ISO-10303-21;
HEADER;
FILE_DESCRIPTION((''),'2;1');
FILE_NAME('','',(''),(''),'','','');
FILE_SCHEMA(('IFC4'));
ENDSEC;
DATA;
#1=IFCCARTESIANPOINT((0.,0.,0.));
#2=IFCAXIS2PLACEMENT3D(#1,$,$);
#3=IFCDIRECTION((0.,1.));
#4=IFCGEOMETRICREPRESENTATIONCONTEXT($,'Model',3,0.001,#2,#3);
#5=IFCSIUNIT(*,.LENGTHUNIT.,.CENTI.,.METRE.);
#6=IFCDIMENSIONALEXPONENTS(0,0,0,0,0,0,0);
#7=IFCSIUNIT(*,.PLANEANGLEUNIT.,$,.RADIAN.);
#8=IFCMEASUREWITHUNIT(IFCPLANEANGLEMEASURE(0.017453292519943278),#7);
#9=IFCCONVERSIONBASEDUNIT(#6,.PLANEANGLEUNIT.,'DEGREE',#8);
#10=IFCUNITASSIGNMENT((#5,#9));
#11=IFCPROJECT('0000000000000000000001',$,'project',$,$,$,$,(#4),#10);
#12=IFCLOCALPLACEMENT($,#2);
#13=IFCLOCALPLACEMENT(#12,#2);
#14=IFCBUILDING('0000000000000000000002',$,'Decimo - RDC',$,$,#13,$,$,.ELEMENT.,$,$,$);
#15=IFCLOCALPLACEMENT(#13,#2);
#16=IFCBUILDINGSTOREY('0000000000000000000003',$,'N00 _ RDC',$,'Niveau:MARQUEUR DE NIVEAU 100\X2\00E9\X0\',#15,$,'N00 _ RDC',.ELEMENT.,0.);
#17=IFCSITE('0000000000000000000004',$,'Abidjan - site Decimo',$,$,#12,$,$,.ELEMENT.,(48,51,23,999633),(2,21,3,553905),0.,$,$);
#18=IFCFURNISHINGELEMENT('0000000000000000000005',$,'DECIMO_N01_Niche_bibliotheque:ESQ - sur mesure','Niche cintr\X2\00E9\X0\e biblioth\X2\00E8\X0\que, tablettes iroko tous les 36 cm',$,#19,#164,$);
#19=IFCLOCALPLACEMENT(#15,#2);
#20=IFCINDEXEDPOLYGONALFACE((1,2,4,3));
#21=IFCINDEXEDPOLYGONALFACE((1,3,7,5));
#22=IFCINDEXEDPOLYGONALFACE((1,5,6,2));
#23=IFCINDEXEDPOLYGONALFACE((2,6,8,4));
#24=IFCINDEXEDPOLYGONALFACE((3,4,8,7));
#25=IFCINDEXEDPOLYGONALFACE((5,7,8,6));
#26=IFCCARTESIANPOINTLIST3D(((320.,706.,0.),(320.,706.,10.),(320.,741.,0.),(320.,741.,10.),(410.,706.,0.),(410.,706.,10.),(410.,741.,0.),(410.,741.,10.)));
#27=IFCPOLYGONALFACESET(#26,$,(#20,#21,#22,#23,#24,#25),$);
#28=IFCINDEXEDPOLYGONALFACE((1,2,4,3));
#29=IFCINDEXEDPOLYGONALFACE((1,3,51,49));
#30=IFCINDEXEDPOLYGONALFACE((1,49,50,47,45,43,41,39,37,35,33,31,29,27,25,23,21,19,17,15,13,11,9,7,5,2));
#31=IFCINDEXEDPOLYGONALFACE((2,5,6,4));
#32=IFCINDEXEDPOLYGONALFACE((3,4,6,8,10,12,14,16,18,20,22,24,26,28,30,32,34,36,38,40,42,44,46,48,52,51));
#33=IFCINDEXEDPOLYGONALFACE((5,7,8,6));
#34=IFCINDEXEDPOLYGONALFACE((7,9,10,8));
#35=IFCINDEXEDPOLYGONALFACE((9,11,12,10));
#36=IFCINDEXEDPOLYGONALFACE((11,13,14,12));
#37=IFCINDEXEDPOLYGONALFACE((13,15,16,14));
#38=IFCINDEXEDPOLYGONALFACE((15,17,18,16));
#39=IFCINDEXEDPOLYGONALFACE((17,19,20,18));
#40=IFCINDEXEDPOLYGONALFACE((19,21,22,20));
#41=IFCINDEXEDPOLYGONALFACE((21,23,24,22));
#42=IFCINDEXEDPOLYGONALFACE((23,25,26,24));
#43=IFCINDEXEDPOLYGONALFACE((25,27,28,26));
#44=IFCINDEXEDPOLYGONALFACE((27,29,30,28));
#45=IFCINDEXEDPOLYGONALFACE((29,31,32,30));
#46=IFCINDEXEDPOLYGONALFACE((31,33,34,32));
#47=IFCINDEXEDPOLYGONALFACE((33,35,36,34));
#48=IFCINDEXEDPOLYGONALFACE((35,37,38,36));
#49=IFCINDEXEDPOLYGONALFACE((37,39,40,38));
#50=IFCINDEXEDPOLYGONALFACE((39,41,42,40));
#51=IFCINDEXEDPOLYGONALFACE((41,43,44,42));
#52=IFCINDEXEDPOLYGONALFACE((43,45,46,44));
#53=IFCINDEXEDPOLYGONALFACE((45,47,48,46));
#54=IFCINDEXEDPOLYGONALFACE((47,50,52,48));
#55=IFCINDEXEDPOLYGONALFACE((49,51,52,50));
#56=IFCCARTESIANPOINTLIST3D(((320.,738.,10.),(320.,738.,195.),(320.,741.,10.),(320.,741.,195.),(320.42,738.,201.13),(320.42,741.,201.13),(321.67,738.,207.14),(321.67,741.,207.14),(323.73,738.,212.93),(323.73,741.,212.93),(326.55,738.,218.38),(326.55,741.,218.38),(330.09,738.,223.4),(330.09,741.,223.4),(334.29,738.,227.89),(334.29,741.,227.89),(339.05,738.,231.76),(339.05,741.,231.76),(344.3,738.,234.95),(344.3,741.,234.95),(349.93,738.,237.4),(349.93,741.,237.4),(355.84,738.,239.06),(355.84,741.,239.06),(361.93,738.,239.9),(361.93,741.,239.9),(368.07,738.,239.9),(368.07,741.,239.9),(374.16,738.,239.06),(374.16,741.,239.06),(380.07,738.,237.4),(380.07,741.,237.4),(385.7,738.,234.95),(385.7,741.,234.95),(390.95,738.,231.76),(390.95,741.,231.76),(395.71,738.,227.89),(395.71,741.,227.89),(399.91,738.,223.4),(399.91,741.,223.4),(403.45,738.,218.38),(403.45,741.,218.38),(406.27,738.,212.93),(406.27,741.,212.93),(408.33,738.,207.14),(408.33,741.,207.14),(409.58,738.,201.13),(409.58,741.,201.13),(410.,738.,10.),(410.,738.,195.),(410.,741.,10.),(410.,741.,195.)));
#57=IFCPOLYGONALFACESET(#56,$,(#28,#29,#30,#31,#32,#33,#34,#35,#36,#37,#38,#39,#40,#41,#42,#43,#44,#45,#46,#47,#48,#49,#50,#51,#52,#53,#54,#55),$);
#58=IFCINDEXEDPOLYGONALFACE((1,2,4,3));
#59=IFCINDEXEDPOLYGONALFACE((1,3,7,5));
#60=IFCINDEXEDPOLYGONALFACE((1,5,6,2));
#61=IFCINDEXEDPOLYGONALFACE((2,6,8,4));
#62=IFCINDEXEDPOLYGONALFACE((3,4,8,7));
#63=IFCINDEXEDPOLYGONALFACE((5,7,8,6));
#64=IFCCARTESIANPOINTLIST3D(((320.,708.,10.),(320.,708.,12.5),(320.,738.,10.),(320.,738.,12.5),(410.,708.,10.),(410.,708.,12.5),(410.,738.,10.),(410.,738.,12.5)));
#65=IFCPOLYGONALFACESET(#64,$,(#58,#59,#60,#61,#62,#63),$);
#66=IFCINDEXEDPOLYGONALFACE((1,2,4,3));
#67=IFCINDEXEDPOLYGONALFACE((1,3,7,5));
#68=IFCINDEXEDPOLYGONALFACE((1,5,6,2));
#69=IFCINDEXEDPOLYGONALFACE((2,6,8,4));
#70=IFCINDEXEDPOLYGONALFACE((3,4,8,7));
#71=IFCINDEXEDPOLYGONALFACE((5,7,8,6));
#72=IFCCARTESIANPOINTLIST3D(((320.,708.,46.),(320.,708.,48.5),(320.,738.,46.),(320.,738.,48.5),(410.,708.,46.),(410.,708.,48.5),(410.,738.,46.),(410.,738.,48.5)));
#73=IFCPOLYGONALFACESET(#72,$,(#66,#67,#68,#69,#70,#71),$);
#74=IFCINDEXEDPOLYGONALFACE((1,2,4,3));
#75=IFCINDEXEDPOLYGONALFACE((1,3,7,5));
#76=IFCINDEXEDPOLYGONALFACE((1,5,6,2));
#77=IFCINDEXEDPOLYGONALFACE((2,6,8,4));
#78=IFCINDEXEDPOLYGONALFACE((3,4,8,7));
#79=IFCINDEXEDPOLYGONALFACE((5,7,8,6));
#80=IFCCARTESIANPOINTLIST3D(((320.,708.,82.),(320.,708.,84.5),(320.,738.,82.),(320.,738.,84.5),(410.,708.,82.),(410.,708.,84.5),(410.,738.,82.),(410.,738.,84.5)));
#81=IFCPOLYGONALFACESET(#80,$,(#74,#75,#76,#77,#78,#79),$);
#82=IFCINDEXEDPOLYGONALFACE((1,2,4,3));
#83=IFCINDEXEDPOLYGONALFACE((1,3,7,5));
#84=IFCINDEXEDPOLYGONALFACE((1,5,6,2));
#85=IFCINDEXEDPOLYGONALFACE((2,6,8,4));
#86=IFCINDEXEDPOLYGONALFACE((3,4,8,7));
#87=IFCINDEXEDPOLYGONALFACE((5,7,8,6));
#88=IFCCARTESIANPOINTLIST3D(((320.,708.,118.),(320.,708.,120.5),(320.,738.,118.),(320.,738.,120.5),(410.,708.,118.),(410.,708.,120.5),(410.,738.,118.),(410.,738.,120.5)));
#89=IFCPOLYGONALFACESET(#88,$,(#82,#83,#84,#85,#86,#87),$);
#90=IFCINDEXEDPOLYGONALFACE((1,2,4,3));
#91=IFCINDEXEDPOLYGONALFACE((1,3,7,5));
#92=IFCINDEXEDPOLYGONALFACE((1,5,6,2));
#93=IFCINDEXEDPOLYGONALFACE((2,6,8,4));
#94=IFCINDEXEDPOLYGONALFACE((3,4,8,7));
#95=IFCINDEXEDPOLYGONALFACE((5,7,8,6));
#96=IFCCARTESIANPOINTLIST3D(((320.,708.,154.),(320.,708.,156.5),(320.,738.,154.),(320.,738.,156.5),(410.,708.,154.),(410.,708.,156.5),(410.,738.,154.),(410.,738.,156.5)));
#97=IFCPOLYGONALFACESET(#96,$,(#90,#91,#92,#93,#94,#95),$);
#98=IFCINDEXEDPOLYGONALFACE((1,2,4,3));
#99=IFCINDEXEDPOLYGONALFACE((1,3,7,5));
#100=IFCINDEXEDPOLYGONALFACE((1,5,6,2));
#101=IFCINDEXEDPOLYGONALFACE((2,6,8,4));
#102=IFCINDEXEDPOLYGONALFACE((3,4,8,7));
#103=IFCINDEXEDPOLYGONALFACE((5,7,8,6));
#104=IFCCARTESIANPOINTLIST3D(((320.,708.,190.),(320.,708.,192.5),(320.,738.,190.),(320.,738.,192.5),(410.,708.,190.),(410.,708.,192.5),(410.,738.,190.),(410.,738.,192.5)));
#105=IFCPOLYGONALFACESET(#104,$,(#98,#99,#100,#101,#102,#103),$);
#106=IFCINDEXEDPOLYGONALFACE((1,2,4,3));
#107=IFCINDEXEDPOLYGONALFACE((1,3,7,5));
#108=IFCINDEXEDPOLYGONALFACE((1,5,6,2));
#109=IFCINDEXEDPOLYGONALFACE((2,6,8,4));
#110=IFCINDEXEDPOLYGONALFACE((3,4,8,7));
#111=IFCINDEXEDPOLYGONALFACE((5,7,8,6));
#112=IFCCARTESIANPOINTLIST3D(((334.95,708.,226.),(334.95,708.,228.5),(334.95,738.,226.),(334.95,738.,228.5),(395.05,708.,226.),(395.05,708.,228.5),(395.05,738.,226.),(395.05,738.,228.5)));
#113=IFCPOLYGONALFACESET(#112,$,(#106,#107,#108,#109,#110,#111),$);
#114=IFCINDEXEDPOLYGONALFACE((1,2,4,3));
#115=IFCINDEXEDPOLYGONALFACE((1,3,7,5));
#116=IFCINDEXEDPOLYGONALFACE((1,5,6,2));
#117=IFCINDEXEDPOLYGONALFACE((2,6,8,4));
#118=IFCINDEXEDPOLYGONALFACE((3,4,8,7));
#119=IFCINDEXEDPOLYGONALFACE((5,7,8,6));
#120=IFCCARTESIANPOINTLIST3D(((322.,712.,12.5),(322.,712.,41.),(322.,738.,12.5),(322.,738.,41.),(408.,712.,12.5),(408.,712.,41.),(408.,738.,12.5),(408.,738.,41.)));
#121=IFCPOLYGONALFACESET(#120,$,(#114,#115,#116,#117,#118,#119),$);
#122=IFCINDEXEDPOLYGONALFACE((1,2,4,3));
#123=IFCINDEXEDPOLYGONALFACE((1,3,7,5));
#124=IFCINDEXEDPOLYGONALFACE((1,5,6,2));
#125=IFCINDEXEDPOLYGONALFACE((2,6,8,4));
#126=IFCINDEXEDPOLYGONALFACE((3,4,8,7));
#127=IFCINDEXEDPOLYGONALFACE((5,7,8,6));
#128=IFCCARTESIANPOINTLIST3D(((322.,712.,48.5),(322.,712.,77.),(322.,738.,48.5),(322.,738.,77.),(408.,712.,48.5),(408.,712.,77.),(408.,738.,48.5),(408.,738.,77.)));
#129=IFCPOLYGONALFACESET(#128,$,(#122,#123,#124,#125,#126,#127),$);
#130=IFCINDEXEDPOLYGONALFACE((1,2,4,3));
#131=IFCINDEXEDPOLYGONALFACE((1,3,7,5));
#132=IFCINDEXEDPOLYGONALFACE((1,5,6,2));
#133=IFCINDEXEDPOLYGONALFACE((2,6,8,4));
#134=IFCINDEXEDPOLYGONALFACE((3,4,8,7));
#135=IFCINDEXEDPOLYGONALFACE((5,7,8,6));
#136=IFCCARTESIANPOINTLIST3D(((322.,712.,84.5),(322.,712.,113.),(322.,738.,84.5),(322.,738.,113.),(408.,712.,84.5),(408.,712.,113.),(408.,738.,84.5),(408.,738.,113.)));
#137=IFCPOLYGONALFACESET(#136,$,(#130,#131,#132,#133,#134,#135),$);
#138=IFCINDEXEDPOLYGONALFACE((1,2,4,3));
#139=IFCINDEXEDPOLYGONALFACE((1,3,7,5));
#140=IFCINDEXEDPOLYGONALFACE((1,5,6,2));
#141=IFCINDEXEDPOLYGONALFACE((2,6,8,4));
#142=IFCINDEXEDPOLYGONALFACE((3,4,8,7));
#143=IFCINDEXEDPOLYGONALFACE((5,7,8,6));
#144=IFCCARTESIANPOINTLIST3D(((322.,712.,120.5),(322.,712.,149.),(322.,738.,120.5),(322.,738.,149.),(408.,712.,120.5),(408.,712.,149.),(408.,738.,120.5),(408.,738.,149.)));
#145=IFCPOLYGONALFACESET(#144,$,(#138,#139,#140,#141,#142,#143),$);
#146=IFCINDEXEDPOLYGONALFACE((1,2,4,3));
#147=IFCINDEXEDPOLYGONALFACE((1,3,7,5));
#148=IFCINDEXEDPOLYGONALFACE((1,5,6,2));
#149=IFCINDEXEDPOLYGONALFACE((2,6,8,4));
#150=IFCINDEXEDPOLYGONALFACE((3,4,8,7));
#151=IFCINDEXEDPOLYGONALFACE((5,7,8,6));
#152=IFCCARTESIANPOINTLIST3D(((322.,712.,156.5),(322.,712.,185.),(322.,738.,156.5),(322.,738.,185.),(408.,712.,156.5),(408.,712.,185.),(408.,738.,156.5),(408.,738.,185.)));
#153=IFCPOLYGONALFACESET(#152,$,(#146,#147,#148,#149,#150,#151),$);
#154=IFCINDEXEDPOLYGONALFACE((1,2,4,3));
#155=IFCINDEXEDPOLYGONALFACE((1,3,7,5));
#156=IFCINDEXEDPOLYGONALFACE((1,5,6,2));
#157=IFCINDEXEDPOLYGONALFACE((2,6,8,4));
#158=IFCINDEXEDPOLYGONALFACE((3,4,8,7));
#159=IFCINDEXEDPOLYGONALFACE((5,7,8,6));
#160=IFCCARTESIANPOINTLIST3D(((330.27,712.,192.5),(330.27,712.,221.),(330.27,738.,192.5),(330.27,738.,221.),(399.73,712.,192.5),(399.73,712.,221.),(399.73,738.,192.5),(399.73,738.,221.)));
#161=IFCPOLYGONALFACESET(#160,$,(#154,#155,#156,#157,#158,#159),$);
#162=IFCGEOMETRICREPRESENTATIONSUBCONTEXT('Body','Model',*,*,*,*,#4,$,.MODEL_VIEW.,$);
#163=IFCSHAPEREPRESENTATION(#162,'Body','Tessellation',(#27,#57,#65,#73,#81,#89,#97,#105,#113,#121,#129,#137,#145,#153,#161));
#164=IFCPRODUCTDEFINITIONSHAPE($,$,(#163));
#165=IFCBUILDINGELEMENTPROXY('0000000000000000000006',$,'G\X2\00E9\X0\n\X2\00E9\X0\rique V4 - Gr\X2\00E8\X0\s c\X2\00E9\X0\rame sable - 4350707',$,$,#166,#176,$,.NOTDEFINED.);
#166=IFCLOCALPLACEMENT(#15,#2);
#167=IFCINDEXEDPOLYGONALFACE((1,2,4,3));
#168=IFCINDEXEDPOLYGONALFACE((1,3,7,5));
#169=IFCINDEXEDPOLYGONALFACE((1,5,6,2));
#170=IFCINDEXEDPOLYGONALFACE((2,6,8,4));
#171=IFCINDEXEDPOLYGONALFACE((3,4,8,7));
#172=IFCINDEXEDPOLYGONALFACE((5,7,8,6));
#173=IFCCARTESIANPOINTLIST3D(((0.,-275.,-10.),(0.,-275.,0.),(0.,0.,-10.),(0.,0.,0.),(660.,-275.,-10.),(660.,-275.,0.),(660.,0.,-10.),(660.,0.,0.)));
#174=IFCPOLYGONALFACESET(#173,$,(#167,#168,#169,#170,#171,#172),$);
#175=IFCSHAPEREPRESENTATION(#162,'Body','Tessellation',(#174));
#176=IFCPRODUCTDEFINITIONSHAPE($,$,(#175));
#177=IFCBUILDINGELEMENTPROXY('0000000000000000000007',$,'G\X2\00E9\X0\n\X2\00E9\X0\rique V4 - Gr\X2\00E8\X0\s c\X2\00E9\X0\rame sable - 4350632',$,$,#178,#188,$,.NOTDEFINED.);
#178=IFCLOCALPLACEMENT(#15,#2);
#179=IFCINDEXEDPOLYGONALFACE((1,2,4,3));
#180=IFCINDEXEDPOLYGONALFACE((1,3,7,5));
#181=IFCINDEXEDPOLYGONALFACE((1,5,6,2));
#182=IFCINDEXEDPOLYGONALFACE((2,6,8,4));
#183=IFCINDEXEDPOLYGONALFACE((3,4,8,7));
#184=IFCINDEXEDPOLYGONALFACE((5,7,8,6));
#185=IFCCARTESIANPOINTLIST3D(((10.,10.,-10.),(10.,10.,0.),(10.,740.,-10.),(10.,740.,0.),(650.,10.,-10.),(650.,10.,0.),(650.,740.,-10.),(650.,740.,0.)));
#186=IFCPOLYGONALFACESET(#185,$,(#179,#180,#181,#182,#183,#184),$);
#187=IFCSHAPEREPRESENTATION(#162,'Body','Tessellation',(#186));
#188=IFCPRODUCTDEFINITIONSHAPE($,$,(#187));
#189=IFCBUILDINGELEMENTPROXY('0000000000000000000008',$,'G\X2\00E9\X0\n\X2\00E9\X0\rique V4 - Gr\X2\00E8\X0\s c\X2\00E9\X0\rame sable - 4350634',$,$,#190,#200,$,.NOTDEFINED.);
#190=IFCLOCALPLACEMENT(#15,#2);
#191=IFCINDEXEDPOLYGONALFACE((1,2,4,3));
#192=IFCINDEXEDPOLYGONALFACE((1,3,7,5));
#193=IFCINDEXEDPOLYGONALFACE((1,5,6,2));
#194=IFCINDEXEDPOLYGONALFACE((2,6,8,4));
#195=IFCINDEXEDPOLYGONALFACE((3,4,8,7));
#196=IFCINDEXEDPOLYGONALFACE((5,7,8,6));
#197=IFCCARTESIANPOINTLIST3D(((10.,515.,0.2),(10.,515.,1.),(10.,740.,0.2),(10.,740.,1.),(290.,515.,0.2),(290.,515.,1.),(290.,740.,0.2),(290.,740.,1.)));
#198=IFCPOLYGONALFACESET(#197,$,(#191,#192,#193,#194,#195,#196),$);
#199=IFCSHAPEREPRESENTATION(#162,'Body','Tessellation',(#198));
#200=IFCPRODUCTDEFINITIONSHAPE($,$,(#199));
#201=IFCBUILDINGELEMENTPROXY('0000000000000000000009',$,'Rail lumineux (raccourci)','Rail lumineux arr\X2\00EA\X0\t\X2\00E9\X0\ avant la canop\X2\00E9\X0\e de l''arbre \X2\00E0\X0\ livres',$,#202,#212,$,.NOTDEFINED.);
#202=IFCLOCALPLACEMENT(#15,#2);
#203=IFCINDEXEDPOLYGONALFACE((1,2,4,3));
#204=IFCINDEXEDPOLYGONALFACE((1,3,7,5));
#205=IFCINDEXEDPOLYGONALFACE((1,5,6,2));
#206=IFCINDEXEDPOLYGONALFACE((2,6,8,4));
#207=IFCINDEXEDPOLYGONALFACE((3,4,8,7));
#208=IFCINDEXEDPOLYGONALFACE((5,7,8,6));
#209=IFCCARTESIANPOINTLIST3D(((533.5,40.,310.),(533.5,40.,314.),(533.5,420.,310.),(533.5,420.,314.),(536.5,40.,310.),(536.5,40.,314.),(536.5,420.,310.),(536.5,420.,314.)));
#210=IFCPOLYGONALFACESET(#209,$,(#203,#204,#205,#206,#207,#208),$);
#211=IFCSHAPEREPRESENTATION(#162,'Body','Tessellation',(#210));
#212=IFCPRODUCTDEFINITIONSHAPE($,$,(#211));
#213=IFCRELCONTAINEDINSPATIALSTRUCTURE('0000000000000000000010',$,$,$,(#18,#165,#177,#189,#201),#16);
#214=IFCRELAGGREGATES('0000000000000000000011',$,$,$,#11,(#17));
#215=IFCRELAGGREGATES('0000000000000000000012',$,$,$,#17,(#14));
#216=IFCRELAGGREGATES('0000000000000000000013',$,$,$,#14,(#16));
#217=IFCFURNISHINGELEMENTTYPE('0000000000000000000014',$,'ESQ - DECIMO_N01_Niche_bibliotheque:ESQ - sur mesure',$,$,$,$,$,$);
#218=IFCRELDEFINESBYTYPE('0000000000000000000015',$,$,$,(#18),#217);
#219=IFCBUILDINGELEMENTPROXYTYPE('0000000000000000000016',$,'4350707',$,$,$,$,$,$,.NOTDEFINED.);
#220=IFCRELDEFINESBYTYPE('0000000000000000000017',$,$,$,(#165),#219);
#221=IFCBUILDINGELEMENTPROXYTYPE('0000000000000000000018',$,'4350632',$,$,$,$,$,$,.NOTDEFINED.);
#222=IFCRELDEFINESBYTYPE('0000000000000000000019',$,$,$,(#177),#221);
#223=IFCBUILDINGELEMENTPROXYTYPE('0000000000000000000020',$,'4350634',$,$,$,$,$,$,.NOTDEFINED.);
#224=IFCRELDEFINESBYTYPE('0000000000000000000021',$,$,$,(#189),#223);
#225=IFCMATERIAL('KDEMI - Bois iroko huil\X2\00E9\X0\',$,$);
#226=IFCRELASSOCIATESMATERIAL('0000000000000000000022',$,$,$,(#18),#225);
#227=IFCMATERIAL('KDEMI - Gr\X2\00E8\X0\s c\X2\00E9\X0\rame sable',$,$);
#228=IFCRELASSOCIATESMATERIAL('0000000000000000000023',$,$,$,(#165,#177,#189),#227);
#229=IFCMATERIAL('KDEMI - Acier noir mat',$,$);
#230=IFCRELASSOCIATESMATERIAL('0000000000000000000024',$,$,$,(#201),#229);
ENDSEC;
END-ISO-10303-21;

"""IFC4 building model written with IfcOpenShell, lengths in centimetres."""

from ifc_helpers import new_model, entity, si_unit, converted_unit, direction, frame, frame_2d, origin, origin_with_axes, origin_2d_with_axis, place, context, subcontext, project, spatial, polyline, rectangle, outline, extrude, material, type_object, element, save


model = new_model("IFC4")

# Units and contexts
model_context = context("Model", 3, precision=0.001, world=origin(), true_north=direction((0.0, 1.0)))
body_context = subcontext(model_context, "Body", "Model", "MODEL_VIEW")
ifc_project = project(units=[si_unit("LENGTHUNIT", "METRE", prefix="CENTI"), converted_unit("PLANEANGLEUNIT", "DEGREE", entity("IfcPlaneAngleMeasure", 0.017453292519943278), si_unit("PLANEANGLEUNIT", "RADIAN"), dimensions=[0, 0, 0, 0, 0, 0, 0])], contexts=[model_context])

# Site, building, storey
site_placement = place(None, origin())
site = spatial("IfcSite", under=ifc_project, at=site_placement, Name="Abidjan - site Decimo", CompositionType="ELEMENT", RefLatitude=(48, 51, 23, 999633), RefLongitude=(2, 21, 3, 553905), RefElevation=0.0)
building_placement = place(site_placement, origin())
building = spatial("IfcBuilding", under=site, at=building_placement, Name="Decimo - RDC", CompositionType="ELEMENT")
storey_placement = place(building_placement, origin())
storey = spatial("IfcBuildingStorey", under=building, at=storey_placement, Name="N00 _ RDC", ObjectType="Niveau:MARQUEUR DE NIVEAU 100é", LongName="N00 _ RDC", CompositionType="ELEMENT", Elevation=0.0)

# Shared definitions
ifc_material_1 = material(Name="KDEMI - Acier noir mat")

# Furnishing element
ifc_material_2 = material(Name="KDEMI - Bois iroko huilé")
furnishing_element_type_1 = type_object("IfcFurnishingElementType", Name="ESQ - DECIMO_N01_Niche_bibliotheque:ESQ - sur mesure")
furnishing_1_placement = place(storey_placement, origin_with_axes())
element("IfcFurnishingElement", 1, at=furnishing_1_placement, inside=storey, type_object=furnishing_element_type_1, material=ifc_material_2, Name="DECIMO_N01_Niche_bibliotheque:ESQ - sur mesure", Description="Niche cintrée bibliothèque, tablettes iroko tous les 36 cm", context=body_context, shape_type="SweptSolid", body=[
    extrude(rectangle(XDim=90.0, YDim=35.0, at=frame_2d((365.0, 723.5))), origin(), (0.0, 0.0, 1.0), 10.0),
    extrude(outline(polyline([(320.0, 10.0), (410.0, 10.0), (410.0, 195.0), (409.58, 201.13), (408.33, 207.14), (406.27, 212.93), (403.45, 218.38), (399.91, 223.4), (395.71, 227.89), (390.95, 231.76), (385.7, 234.95), (380.07, 237.4), (374.16, 239.06), (368.07, 239.9), (361.93, 239.9), (355.84, 239.06), (349.93, 237.4), (344.3, 234.95), (339.05, 231.76), (334.29, 227.89), (330.09, 223.4), (326.55, 218.38), (323.73, 212.93), (321.67, 207.14), (320.42, 201.13), (320.0, 195.0), (320.0, 10.0)])), frame((0.0, 741.0, 0.0), z_axis=(0.0, -1.0, 0.0), x_axis=(1.0, 0.0, 0.0)), (0.0, 0.0, 1.0), 3.0),
    extrude(rectangle(XDim=90.0, YDim=30.0, at=frame_2d((365.0, 723.0))), frame((0.0, 0.0, 10.0)), (0.0, 0.0, 1.0), 2.5),
    extrude(rectangle(XDim=90.0, YDim=30.0, at=frame_2d((365.0, 723.0))), frame((0.0, 0.0, 46.0)), (0.0, 0.0, 1.0), 2.5),
    extrude(rectangle(XDim=90.0, YDim=30.0, at=frame_2d((365.0, 723.0))), frame((0.0, 0.0, 82.0)), (0.0, 0.0, 1.0), 2.5),
    extrude(rectangle(XDim=90.0, YDim=30.0, at=frame_2d((365.0, 723.0))), frame((0.0, 0.0, 118.0)), (0.0, 0.0, 1.0), 2.5),
    extrude(rectangle(XDim=90.0, YDim=30.0, at=frame_2d((365.0, 723.0))), frame((0.0, 0.0, 154.0)), (0.0, 0.0, 1.0), 2.5),
    extrude(rectangle(XDim=90.0, YDim=30.0, at=frame_2d((365.0, 723.0))), frame((0.0, 0.0, 190.0)), (0.0, 0.0, 1.0), 2.5),
    extrude(rectangle(XDim=60.09, YDim=30.0, at=frame_2d((365.0, 723.0))), frame((0.0, 0.0, 226.0)), (0.0, 0.0, 1.0), 2.5),
    extrude(rectangle(XDim=86.0, YDim=26.0, at=frame_2d((365.0, 725.0))), frame((0.0, 0.0, 12.5)), (0.0, 0.0, 1.0), 28.5),
    extrude(rectangle(XDim=86.0, YDim=26.0, at=frame_2d((365.0, 725.0))), frame((0.0, 0.0, 48.5)), (0.0, 0.0, 1.0), 28.5),
    extrude(rectangle(XDim=86.0, YDim=26.0, at=frame_2d((365.0, 725.0))), frame((0.0, 0.0, 84.5)), (0.0, 0.0, 1.0), 28.5),
    extrude(rectangle(XDim=86.0, YDim=26.0, at=frame_2d((365.0, 725.0))), frame((0.0, 0.0, 120.5)), (0.0, 0.0, 1.0), 28.5),
    extrude(rectangle(XDim=86.0, YDim=26.0, at=frame_2d((365.0, 725.0))), frame((0.0, 0.0, 156.5)), (0.0, 0.0, 1.0), 28.5),
    extrude(rectangle(XDim=69.46, YDim=26.0, at=frame_2d((365.0, 725.0))), frame((0.0, 0.0, 192.5)), (0.0, 0.0, 1.0), 28.5),
])

# Building element proxies
ifc_material_3 = material(Name="KDEMI - Grès cérame sable")
building_element_proxy_type_1 = type_object("IfcBuildingElementProxyType", Name="4350707", PredefinedType="NOTDEFINED")
proxy_1_placement = place(storey_placement, origin())
element("IfcBuildingElementProxy", 2, at=proxy_1_placement, inside=storey, type_object=building_element_proxy_type_1, material=ifc_material_3, Name="Générique V4 - Grès cérame sable - 4350707", PredefinedType="NOTDEFINED", context=body_context, shape_type="SweptSolid", body=[
    extrude(rectangle(XDim=660.0, YDim=275.0, at=origin_2d_with_axis()), frame((330.0, -137.5, -10.0)), (0.0, 0.0, 1.0), 10.0),
])
building_element_proxy_type_2 = type_object("IfcBuildingElementProxyType", Name="4350632", PredefinedType="NOTDEFINED")
proxy_2_placement = place(storey_placement, origin())
element("IfcBuildingElementProxy", 3, at=proxy_2_placement, inside=storey, type_object=building_element_proxy_type_2, material=ifc_material_3, Name="Générique V4 - Grès cérame sable - 4350632", PredefinedType="NOTDEFINED", context=body_context, shape_type="SweptSolid", body=[
    extrude(rectangle(XDim=640.0, YDim=730.0, at=origin_2d_with_axis()), frame((330.0, 375.0, -10.0)), (0.0, 0.0, 1.0), 10.0),
])
building_element_proxy_type_3 = type_object("IfcBuildingElementProxyType", Name="4350634", PredefinedType="NOTDEFINED")
proxy_3_placement = place(storey_placement, origin())
element("IfcBuildingElementProxy", 4, at=proxy_3_placement, inside=storey, type_object=building_element_proxy_type_3, material=ifc_material_3, Name="Générique V4 - Grès cérame sable - 4350634", PredefinedType="NOTDEFINED", context=body_context, shape_type="SweptSolid", body=[
    extrude(rectangle(XDim=280.0, YDim=225.0, at=frame_2d((0.0, 0.0), x_axis=(1.0, 0.0))), frame((150.0, 627.5, 0.2)), (0.0, 0.0, 1.0), 0.8),
])
proxy_4_placement = place(storey_placement, origin_with_axes())
element("IfcBuildingElementProxy", 5, at=proxy_4_placement, inside=storey, material=ifc_material_1, Name="Rail lumineux (raccourci)", Description="Rail lumineux arrêté avant la canopée de l'arbre à livres", PredefinedType="NOTDEFINED", context=body_context, shape_type="SweptSolid", body=[
    extrude(rectangle(XDim=3.0, YDim=380.0, at=frame_2d((535.0, 230.0))), frame((0.0, 0.0, 310.0)), (0.0, 0.0, 1.0), 4.0),
])

save(model, "model.ifc")
